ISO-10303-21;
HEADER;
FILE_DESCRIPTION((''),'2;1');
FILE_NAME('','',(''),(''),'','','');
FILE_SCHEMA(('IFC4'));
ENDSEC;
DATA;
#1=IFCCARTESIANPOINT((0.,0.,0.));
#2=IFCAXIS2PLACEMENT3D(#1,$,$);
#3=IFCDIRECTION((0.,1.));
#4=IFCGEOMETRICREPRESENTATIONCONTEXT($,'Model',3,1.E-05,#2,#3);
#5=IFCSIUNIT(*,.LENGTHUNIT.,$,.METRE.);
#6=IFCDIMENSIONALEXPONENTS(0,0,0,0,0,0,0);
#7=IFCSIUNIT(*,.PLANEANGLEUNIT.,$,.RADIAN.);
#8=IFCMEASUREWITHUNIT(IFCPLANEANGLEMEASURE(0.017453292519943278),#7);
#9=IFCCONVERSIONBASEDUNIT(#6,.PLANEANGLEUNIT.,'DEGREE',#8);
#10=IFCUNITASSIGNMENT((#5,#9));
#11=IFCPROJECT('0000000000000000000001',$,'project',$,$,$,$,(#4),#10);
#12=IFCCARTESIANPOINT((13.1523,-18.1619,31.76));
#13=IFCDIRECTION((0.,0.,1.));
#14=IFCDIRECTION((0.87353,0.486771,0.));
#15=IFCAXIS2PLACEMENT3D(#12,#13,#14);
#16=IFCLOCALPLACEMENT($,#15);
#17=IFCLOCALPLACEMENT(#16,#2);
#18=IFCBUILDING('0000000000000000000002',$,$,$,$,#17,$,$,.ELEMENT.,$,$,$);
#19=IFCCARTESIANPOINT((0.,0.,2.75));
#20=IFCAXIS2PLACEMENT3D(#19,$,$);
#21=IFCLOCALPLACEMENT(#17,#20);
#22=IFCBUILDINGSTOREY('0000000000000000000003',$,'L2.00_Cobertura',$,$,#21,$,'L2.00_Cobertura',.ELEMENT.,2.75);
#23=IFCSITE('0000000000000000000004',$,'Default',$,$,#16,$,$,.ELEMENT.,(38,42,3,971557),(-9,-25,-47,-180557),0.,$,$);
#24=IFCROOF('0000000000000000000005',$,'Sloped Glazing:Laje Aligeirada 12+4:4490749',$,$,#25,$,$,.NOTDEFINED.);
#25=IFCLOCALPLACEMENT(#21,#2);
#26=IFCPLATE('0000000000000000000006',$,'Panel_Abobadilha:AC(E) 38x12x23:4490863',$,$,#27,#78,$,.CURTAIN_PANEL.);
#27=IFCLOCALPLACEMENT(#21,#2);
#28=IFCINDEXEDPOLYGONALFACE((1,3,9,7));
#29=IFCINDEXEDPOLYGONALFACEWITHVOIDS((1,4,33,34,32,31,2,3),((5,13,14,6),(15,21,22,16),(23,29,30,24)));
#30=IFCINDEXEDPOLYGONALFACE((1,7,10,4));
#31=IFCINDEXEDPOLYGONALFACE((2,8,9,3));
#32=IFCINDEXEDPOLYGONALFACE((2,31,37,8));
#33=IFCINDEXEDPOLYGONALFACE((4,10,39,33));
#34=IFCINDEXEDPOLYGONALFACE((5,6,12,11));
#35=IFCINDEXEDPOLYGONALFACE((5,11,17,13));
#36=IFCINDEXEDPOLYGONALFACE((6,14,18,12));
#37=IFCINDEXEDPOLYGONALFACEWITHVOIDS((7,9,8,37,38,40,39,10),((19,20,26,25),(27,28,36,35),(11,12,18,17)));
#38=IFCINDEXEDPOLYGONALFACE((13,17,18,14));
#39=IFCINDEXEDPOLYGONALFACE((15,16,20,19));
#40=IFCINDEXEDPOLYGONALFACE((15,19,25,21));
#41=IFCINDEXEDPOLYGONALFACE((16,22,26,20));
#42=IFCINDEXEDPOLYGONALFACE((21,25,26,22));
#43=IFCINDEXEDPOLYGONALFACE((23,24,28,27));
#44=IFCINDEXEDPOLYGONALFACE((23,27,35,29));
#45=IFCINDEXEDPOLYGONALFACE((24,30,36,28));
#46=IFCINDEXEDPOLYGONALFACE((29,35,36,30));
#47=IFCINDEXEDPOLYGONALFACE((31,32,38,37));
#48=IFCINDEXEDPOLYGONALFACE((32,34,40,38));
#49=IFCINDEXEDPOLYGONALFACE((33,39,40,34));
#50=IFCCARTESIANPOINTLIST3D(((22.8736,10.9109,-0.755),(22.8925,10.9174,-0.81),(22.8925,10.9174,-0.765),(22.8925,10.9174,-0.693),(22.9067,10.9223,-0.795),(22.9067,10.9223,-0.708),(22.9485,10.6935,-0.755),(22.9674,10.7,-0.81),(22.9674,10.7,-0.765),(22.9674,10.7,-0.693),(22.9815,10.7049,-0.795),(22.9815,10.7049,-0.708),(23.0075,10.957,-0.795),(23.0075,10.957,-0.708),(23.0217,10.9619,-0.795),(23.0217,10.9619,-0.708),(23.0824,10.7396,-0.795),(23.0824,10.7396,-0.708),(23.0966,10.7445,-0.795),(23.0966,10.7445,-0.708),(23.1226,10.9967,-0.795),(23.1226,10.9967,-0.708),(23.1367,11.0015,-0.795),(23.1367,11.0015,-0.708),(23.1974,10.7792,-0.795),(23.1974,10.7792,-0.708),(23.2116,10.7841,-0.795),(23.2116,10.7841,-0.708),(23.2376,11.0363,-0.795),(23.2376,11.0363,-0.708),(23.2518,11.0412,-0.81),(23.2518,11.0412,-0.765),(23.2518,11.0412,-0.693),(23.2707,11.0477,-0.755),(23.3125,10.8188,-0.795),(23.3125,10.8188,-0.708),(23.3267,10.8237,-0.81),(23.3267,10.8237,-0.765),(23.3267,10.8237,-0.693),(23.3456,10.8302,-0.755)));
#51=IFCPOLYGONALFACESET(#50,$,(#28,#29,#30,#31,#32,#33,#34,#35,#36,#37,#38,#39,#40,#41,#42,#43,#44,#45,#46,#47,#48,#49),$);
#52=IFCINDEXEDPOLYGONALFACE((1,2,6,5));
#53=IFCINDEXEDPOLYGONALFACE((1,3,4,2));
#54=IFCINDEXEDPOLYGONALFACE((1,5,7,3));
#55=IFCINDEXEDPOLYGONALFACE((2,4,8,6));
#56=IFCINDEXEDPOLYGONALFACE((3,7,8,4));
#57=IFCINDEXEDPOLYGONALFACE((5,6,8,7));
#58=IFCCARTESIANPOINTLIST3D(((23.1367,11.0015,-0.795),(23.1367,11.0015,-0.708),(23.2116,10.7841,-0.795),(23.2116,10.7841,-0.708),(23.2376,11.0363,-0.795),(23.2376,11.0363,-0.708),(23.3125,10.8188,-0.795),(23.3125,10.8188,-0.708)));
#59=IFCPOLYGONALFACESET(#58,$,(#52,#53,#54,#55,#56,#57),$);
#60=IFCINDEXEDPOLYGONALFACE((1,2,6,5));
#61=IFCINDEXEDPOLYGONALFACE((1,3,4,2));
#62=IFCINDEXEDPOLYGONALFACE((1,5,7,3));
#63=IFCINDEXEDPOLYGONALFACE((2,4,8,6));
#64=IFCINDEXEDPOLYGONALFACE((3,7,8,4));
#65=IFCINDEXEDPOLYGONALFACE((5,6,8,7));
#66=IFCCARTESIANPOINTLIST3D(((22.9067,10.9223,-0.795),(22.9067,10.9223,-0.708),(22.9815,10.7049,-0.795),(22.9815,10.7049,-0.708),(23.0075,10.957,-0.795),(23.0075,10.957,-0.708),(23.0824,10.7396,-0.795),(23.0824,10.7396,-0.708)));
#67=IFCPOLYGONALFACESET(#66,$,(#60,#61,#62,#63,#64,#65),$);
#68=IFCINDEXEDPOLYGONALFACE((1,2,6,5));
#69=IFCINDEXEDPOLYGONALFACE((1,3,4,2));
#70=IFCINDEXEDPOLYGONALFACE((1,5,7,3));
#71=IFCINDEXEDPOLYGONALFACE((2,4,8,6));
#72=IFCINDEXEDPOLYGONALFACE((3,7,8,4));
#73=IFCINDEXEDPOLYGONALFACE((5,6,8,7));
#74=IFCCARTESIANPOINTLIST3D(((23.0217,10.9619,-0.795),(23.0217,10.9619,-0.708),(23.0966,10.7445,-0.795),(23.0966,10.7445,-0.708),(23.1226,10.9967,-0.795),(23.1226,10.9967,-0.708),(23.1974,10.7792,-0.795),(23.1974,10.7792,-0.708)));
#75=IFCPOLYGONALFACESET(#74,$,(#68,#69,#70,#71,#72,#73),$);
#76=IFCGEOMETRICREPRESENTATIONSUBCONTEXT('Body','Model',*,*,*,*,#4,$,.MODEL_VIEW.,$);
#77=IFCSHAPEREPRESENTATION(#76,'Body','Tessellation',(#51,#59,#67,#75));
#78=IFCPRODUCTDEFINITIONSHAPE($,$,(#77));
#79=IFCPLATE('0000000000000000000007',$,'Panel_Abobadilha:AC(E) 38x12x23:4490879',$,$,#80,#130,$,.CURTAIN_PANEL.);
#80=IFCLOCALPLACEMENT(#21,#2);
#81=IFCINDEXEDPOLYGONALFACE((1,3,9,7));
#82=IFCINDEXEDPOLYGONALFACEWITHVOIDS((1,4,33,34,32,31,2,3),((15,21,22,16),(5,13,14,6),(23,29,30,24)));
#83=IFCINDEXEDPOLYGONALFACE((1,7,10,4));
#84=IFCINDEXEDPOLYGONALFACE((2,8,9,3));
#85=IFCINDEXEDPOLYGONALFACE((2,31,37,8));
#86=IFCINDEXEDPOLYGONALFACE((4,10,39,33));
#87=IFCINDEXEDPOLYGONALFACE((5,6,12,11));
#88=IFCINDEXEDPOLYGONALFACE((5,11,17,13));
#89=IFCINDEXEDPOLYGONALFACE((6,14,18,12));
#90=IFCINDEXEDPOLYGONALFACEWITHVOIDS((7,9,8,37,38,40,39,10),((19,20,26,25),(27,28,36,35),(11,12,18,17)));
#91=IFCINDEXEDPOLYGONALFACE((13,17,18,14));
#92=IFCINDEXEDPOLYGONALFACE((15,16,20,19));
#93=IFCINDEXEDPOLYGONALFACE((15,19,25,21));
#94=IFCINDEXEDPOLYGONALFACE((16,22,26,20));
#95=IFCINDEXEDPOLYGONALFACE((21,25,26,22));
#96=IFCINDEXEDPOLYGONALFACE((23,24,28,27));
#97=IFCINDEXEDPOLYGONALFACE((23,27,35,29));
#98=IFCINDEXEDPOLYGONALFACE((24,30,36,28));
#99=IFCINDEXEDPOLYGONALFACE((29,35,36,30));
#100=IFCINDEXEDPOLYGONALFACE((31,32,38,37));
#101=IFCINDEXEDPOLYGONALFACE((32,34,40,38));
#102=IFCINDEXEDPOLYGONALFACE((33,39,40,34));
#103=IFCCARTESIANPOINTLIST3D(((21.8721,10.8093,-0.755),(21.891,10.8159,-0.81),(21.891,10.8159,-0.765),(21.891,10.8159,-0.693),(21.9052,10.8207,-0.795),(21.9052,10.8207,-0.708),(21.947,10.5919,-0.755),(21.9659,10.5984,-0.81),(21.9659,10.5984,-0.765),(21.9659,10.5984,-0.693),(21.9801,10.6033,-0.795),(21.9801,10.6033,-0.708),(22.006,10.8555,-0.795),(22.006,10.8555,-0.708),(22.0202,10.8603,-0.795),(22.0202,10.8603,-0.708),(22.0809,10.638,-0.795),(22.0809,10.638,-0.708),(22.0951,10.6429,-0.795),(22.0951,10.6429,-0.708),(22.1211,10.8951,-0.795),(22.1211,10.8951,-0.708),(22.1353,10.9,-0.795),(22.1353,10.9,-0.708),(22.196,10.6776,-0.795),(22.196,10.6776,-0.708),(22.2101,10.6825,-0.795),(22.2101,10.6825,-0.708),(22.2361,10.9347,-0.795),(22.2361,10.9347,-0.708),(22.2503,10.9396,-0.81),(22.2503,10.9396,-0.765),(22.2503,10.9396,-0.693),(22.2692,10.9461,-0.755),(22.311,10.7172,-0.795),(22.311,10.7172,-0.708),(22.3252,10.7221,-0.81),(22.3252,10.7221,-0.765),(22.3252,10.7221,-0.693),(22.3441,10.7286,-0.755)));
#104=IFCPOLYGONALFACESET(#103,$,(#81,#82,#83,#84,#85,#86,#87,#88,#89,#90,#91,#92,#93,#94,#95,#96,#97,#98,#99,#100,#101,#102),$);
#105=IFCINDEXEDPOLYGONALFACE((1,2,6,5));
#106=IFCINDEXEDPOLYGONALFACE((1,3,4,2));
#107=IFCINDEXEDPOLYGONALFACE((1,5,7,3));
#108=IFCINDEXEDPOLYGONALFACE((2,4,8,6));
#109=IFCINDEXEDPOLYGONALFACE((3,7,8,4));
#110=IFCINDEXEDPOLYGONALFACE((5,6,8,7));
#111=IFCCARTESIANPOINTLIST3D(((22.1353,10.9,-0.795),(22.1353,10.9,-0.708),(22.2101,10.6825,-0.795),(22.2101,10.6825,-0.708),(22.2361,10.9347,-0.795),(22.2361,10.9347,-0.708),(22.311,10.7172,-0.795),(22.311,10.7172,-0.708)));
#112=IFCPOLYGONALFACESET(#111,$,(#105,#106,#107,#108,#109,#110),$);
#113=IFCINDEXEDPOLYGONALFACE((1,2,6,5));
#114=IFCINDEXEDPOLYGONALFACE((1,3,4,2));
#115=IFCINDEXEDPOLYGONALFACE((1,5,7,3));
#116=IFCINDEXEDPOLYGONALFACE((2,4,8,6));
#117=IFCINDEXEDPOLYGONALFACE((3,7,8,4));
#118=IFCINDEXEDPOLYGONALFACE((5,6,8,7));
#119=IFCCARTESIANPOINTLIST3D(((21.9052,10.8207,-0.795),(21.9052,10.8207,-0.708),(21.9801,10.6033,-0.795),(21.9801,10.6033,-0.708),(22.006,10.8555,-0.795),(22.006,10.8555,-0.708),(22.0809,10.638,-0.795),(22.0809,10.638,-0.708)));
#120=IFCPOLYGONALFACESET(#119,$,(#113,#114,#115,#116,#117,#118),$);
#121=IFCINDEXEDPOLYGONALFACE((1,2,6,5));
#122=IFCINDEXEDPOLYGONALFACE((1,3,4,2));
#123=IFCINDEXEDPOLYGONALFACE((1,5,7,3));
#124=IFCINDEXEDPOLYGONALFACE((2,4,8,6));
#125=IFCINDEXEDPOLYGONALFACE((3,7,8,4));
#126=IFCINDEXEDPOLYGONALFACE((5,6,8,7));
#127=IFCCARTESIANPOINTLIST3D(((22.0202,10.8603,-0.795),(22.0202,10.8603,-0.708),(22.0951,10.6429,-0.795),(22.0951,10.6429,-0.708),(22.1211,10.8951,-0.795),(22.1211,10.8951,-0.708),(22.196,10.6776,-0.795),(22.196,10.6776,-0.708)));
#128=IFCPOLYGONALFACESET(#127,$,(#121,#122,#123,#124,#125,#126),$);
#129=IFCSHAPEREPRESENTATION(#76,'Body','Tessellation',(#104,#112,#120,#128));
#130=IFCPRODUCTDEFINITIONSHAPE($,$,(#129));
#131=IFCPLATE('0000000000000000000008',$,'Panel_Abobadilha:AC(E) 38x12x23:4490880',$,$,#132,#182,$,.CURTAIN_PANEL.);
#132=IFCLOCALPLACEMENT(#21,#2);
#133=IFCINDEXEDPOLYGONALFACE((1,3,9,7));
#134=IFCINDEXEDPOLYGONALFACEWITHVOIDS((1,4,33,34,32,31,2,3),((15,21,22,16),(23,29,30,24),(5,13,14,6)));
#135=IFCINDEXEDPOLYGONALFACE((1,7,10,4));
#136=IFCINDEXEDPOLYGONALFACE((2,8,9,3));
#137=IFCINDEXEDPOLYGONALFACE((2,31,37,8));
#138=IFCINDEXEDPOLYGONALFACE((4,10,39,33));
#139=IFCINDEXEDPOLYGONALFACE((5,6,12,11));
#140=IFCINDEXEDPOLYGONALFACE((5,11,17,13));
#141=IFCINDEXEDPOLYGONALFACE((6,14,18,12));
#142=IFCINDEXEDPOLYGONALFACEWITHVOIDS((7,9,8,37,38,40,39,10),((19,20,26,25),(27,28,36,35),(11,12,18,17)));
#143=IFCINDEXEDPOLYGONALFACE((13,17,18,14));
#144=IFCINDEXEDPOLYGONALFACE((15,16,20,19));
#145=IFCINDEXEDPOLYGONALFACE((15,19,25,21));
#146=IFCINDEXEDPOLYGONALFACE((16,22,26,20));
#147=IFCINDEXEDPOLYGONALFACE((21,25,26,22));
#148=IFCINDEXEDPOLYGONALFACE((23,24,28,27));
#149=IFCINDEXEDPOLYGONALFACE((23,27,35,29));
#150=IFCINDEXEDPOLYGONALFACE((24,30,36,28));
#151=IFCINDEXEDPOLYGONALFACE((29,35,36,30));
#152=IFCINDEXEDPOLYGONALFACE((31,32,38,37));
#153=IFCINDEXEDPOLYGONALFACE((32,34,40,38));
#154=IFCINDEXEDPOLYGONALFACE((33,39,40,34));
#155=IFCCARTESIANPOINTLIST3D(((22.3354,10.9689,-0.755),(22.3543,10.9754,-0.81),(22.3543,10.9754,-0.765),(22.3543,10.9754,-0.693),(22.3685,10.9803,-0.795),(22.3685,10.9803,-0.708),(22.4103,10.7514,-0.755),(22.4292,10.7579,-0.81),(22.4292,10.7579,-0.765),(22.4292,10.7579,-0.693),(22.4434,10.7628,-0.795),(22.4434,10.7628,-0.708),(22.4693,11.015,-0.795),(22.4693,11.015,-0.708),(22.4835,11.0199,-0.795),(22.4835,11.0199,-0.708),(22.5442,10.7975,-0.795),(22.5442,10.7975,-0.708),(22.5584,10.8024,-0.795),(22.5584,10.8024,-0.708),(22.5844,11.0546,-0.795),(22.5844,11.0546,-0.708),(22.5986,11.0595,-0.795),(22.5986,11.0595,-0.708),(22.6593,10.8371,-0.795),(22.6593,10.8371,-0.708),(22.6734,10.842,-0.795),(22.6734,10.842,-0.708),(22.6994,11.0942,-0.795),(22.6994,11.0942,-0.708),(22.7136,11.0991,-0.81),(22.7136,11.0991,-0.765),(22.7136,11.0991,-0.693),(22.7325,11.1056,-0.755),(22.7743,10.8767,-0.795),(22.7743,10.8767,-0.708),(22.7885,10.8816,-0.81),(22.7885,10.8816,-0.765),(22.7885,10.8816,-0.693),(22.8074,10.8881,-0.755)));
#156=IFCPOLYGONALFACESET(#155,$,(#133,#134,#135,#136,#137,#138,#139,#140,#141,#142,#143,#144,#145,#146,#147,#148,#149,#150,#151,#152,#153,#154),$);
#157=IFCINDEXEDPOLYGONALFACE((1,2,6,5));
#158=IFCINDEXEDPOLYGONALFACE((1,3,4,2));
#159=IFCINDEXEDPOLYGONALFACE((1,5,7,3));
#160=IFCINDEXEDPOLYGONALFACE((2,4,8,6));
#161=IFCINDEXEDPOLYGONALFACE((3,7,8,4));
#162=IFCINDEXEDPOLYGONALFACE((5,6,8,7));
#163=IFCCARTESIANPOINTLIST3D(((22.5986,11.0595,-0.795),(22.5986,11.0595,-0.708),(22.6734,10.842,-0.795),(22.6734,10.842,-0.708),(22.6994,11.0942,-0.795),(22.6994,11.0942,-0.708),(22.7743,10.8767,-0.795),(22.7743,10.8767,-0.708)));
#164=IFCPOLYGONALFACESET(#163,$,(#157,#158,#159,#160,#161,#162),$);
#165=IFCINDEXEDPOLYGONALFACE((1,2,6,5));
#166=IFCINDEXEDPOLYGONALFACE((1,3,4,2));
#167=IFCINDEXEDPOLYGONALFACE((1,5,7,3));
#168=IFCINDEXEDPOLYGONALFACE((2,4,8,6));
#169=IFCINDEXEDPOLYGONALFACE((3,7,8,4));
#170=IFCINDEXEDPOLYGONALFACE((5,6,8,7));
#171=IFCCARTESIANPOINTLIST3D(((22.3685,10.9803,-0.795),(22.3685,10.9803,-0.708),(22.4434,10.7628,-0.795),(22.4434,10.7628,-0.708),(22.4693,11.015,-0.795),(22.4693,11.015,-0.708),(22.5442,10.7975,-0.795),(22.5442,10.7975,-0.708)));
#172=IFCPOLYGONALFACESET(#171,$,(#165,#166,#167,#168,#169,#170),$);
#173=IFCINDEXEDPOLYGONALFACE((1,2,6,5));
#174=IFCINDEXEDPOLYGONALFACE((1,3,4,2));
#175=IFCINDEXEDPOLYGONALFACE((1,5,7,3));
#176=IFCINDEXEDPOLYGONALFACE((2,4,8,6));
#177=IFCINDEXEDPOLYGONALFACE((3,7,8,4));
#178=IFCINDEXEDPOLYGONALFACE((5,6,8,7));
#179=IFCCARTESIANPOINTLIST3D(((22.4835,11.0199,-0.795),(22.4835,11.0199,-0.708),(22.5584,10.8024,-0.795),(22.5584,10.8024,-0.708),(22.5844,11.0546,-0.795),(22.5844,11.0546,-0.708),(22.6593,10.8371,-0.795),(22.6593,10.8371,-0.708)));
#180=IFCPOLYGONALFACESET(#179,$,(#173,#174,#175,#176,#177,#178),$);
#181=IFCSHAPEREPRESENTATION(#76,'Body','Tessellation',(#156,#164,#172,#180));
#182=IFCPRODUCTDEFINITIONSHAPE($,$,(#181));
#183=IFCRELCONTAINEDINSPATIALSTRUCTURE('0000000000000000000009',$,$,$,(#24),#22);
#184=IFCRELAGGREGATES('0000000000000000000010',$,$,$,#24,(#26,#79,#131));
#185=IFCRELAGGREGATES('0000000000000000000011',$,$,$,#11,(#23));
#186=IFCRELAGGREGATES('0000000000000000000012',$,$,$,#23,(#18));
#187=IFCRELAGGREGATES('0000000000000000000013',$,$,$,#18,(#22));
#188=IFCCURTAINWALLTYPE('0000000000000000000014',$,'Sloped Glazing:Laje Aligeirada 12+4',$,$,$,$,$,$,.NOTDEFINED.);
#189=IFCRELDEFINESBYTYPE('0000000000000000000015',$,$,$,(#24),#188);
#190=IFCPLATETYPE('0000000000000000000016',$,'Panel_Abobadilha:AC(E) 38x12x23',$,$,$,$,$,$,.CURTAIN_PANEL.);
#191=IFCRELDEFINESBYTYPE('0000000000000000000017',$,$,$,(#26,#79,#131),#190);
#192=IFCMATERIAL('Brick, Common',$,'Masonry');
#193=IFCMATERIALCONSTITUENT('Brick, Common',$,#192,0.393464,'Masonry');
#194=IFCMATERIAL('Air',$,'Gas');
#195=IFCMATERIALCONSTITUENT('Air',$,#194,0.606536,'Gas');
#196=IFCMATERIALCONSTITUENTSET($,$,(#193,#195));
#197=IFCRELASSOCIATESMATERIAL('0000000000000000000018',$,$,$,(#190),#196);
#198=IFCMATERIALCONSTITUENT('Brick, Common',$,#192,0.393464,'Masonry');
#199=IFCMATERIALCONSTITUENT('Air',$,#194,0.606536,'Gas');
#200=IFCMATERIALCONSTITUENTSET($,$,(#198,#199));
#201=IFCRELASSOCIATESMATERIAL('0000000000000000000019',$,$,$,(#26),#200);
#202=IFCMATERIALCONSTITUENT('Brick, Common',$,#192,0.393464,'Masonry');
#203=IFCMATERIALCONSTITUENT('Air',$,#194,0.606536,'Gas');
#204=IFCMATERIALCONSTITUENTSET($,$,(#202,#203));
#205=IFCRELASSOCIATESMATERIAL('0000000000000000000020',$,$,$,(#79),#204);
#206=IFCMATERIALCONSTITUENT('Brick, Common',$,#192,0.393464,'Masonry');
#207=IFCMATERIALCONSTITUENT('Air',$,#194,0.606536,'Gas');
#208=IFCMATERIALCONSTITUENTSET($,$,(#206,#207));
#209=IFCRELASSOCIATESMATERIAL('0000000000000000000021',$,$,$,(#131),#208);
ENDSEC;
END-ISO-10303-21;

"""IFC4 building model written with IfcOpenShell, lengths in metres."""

from ifc_helpers import new_model, entity, si_unit, converted_unit, direction, frame, origin, place, context, subcontext, project, spatial, indexed_curve, outline, extrude, source, transform, mapped, material, constituent, constituent_set, type_object, type_shapes, element, aggregate, save


model = new_model("IFC4")

# Units and contexts
model_context = context("Model", 3, precision=1e-05, world=origin(), true_north=direction((0.0, 1.0)))
body_context = subcontext(model_context, "Body", "Model", "MODEL_VIEW")
ifc_project = project(units=[si_unit("LENGTHUNIT", "METRE"), converted_unit("PLANEANGLEUNIT", "DEGREE", entity("IfcPlaneAngleMeasure", 0.017453292519943278), si_unit("PLANEANGLEUNIT", "RADIAN"), dimensions=[0, 0, 0, 0, 0, 0, 0])], contexts=[model_context])

# Site, building, storey
site_placement = place(None, frame((13.1523, -18.1619, 31.76), z_axis=(0.0, 0.0, 1.0), x_axis=(0.87353, 0.486771, 0.0)))
site = spatial("IfcSite", under=ifc_project, at=site_placement, Name="Default", CompositionType="ELEMENT", RefLatitude=(38, 42, 3, 971557), RefLongitude=(-9, -25, -47, -180557), RefElevation=0.0)
building_placement = place(site_placement, origin())
building = spatial("IfcBuilding", under=site, at=building_placement, CompositionType="ELEMENT")
storey_placement = place(building_placement, frame((0.0, 0.0, 2.75)))
storey = spatial("IfcBuildingStorey", under=building, at=storey_placement, Name="L2.00_Cobertura", LongName="L2.00_Cobertura", CompositionType="ELEMENT", Elevation=2.75)

# Roof
curtain_wall_type = type_object("IfcCurtainWallType", Name="Sloped Glazing:Laje Aligeirada 12+4", PredefinedType="NOTDEFINED")
roof_placement = place(storey_placement, frame((0.0, 0.0, -2.75)))
roof = element("IfcRoof", 1, at=roof_placement, inside=storey, type_object=curtain_wall_type, Name="Sloped Glazing:Laje Aligeirada 12+4:4490749", PredefinedType="NOTDEFINED")

# Plates
ifc_material_1 = material(Name="Brick, Common", Category="Masonry")
ifc_material_2 = material(Name="Air", Category="Gas")
ifc_constituent_1 = constituent(ifc_material_1, Name="Brick, Common", Category="Masonry", fraction=0.393464)
ifc_constituent_2 = constituent(ifc_material_2, Name="Air", Category="Gas", fraction=0.606536)
ifc_constituent_set_1 = constituent_set(constituents=[ifc_constituent_1, ifc_constituent_2])
plate_type_1 = type_object("IfcPlateType", Name="Panel_Abobadilha:AC(E) 38x12x23", PredefinedType="CURTAIN_PANEL", material=ifc_constituent_set_1)
shared_shape_1 = source(origin(), body_context, "Body", "SweptSolid", [
    extrude(outline(indexed_curve([(-0.19, -0.0543), (0.19, -0.0543), (0.19, -0.0093), (0.21, 0.0007), (0.19, 0.0628), (-0.19, 0.0628), (-0.21, 0.0007), (-0.19, -0.0093), (-0.19, -0.0543)], self_intersect=False), holes=[indexed_curve([(-0.0683, 0.0477), (-0.0683, -0.0393), (-0.175, -0.0393), (-0.175, 0.0477), (-0.0683, 0.0477)], self_intersect=False), indexed_curve([(0.0533, 0.0477), (0.0533, -0.0393), (-0.0533, -0.0393), (-0.0533, 0.0477), (0.0533, 0.0477)], self_intersect=False), indexed_curve([(0.175, 0.0477), (0.175, -0.0393), (0.0683, -0.0393), (0.0683, 0.0477), (0.175, 0.0477)], self_intersect=False)]), frame((0.0, 0.0543, 0.0)), (0.0, 0.0, 1.0), 0.23),
    extrude(outline(indexed_curve([(-0.0533, -0.0435), (0.0533, -0.0435), (0.0533, 0.0435), (-0.0533, 0.0435), (-0.0533, -0.0435)], self_intersect=False)), frame((0.1217, 0.0585, 0.0), z_axis=(0.0, 0.0, 1.0), x_axis=(-1.0, 0.0, 0.0)), (0.0, 0.0, 1.0), 0.23),
    extrude(outline(indexed_curve([(-0.0533, -0.0435), (0.0533, -0.0435), (0.0533, 0.0435), (-0.0533, 0.0435), (-0.0533, -0.0435)], self_intersect=False)), frame((-0.1217, 0.0585, 0.0), z_axis=(0.0, 0.0, 1.0), x_axis=(-1.0, 0.0, 0.0)), (0.0, 0.0, 1.0), 0.23),
    extrude(outline(indexed_curve([(-0.0533, -0.0435), (0.0533, -0.0435), (0.0533, 0.0435), (-0.0533, 0.0435), (-0.0533, -0.0435)], self_intersect=False)), frame((0.0, 0.0585, 0.0), z_axis=(0.0, 0.0, 1.0), x_axis=(-1.0, 0.0, 0.0)), (0.0, 0.0, 1.0), 0.23),
])
type_shapes(plate_type_1, [shared_shape_1])
ifc_constituent_3 = constituent(ifc_material_1, Name="Brick, Common", Category="Masonry", fraction=0.393464)
ifc_constituent_4 = constituent(ifc_material_2, Name="Air", Category="Gas", fraction=0.606536)
ifc_constituent_set_2 = constituent_set(constituents=[ifc_constituent_3, ifc_constituent_4])
plate_1_placement = place(roof_placement, frame((23.0721, 10.9793, 1.94), z_axis=(0.325568, -0.945519, 0.0), x_axis=(0.945519, 0.325568, 0.0)))
plate_1 = element("IfcPlate", 2, at=plate_1_placement, type_object=plate_type_1, material=ifc_constituent_set_2, Name="Panel_Abobadilha:AC(E) 38x12x23:4490863", PredefinedType="CURTAIN_PANEL", context=body_context, shape_type="MappedRepresentation", body=[
    mapped(shared_shape_1, transform((0.0, 0.0, 0.0), scale=1.0)),
])
ifc_constituent_5 = constituent(ifc_material_1, Name="Brick, Common", Category="Masonry", fraction=0.393464)
ifc_constituent_6 = constituent(ifc_material_2, Name="Air", Category="Gas", fraction=0.606536)
ifc_constituent_set_3 = constituent_set(constituents=[ifc_constituent_5, ifc_constituent_6])
plate_2_placement = place(roof_placement, frame((22.0706, 10.8777, 1.94), z_axis=(0.325568, -0.945519, 0.0), x_axis=(0.945519, 0.325568, 0.0)))
plate_2 = element("IfcPlate", 3, at=plate_2_placement, type_object=plate_type_1, material=ifc_constituent_set_3, Name="Panel_Abobadilha:AC(E) 38x12x23:4490879", PredefinedType="CURTAIN_PANEL", context=body_context, shape_type="MappedRepresentation", body=[
    mapped(shared_shape_1, transform((0.0, 0.0, 0.0), scale=1.0)),
])
ifc_constituent_7 = constituent(ifc_material_1, Name="Brick, Common", Category="Masonry", fraction=0.393464)
ifc_constituent_8 = constituent(ifc_material_2, Name="Air", Category="Gas", fraction=0.606536)
ifc_constituent_set_4 = constituent_set(constituents=[ifc_constituent_7, ifc_constituent_8])
plate_3_placement = place(roof_placement, frame((22.5339, 11.0372, 1.94), z_axis=(0.325568, -0.945519, 0.0), x_axis=(0.945519, 0.325568, 0.0)))
plate_3 = element("IfcPlate", 4, at=plate_3_placement, type_object=plate_type_1, material=ifc_constituent_set_4, Name="Panel_Abobadilha:AC(E) 38x12x23:4490880", PredefinedType="CURTAIN_PANEL", context=body_context, shape_type="MappedRepresentation", body=[
    mapped(shared_shape_1, transform((0.0, 0.0, 0.0), scale=1.0)),
])
aggregate(roof, [plate_1, plate_2, plate_3])

save(model, "model.ifc")
